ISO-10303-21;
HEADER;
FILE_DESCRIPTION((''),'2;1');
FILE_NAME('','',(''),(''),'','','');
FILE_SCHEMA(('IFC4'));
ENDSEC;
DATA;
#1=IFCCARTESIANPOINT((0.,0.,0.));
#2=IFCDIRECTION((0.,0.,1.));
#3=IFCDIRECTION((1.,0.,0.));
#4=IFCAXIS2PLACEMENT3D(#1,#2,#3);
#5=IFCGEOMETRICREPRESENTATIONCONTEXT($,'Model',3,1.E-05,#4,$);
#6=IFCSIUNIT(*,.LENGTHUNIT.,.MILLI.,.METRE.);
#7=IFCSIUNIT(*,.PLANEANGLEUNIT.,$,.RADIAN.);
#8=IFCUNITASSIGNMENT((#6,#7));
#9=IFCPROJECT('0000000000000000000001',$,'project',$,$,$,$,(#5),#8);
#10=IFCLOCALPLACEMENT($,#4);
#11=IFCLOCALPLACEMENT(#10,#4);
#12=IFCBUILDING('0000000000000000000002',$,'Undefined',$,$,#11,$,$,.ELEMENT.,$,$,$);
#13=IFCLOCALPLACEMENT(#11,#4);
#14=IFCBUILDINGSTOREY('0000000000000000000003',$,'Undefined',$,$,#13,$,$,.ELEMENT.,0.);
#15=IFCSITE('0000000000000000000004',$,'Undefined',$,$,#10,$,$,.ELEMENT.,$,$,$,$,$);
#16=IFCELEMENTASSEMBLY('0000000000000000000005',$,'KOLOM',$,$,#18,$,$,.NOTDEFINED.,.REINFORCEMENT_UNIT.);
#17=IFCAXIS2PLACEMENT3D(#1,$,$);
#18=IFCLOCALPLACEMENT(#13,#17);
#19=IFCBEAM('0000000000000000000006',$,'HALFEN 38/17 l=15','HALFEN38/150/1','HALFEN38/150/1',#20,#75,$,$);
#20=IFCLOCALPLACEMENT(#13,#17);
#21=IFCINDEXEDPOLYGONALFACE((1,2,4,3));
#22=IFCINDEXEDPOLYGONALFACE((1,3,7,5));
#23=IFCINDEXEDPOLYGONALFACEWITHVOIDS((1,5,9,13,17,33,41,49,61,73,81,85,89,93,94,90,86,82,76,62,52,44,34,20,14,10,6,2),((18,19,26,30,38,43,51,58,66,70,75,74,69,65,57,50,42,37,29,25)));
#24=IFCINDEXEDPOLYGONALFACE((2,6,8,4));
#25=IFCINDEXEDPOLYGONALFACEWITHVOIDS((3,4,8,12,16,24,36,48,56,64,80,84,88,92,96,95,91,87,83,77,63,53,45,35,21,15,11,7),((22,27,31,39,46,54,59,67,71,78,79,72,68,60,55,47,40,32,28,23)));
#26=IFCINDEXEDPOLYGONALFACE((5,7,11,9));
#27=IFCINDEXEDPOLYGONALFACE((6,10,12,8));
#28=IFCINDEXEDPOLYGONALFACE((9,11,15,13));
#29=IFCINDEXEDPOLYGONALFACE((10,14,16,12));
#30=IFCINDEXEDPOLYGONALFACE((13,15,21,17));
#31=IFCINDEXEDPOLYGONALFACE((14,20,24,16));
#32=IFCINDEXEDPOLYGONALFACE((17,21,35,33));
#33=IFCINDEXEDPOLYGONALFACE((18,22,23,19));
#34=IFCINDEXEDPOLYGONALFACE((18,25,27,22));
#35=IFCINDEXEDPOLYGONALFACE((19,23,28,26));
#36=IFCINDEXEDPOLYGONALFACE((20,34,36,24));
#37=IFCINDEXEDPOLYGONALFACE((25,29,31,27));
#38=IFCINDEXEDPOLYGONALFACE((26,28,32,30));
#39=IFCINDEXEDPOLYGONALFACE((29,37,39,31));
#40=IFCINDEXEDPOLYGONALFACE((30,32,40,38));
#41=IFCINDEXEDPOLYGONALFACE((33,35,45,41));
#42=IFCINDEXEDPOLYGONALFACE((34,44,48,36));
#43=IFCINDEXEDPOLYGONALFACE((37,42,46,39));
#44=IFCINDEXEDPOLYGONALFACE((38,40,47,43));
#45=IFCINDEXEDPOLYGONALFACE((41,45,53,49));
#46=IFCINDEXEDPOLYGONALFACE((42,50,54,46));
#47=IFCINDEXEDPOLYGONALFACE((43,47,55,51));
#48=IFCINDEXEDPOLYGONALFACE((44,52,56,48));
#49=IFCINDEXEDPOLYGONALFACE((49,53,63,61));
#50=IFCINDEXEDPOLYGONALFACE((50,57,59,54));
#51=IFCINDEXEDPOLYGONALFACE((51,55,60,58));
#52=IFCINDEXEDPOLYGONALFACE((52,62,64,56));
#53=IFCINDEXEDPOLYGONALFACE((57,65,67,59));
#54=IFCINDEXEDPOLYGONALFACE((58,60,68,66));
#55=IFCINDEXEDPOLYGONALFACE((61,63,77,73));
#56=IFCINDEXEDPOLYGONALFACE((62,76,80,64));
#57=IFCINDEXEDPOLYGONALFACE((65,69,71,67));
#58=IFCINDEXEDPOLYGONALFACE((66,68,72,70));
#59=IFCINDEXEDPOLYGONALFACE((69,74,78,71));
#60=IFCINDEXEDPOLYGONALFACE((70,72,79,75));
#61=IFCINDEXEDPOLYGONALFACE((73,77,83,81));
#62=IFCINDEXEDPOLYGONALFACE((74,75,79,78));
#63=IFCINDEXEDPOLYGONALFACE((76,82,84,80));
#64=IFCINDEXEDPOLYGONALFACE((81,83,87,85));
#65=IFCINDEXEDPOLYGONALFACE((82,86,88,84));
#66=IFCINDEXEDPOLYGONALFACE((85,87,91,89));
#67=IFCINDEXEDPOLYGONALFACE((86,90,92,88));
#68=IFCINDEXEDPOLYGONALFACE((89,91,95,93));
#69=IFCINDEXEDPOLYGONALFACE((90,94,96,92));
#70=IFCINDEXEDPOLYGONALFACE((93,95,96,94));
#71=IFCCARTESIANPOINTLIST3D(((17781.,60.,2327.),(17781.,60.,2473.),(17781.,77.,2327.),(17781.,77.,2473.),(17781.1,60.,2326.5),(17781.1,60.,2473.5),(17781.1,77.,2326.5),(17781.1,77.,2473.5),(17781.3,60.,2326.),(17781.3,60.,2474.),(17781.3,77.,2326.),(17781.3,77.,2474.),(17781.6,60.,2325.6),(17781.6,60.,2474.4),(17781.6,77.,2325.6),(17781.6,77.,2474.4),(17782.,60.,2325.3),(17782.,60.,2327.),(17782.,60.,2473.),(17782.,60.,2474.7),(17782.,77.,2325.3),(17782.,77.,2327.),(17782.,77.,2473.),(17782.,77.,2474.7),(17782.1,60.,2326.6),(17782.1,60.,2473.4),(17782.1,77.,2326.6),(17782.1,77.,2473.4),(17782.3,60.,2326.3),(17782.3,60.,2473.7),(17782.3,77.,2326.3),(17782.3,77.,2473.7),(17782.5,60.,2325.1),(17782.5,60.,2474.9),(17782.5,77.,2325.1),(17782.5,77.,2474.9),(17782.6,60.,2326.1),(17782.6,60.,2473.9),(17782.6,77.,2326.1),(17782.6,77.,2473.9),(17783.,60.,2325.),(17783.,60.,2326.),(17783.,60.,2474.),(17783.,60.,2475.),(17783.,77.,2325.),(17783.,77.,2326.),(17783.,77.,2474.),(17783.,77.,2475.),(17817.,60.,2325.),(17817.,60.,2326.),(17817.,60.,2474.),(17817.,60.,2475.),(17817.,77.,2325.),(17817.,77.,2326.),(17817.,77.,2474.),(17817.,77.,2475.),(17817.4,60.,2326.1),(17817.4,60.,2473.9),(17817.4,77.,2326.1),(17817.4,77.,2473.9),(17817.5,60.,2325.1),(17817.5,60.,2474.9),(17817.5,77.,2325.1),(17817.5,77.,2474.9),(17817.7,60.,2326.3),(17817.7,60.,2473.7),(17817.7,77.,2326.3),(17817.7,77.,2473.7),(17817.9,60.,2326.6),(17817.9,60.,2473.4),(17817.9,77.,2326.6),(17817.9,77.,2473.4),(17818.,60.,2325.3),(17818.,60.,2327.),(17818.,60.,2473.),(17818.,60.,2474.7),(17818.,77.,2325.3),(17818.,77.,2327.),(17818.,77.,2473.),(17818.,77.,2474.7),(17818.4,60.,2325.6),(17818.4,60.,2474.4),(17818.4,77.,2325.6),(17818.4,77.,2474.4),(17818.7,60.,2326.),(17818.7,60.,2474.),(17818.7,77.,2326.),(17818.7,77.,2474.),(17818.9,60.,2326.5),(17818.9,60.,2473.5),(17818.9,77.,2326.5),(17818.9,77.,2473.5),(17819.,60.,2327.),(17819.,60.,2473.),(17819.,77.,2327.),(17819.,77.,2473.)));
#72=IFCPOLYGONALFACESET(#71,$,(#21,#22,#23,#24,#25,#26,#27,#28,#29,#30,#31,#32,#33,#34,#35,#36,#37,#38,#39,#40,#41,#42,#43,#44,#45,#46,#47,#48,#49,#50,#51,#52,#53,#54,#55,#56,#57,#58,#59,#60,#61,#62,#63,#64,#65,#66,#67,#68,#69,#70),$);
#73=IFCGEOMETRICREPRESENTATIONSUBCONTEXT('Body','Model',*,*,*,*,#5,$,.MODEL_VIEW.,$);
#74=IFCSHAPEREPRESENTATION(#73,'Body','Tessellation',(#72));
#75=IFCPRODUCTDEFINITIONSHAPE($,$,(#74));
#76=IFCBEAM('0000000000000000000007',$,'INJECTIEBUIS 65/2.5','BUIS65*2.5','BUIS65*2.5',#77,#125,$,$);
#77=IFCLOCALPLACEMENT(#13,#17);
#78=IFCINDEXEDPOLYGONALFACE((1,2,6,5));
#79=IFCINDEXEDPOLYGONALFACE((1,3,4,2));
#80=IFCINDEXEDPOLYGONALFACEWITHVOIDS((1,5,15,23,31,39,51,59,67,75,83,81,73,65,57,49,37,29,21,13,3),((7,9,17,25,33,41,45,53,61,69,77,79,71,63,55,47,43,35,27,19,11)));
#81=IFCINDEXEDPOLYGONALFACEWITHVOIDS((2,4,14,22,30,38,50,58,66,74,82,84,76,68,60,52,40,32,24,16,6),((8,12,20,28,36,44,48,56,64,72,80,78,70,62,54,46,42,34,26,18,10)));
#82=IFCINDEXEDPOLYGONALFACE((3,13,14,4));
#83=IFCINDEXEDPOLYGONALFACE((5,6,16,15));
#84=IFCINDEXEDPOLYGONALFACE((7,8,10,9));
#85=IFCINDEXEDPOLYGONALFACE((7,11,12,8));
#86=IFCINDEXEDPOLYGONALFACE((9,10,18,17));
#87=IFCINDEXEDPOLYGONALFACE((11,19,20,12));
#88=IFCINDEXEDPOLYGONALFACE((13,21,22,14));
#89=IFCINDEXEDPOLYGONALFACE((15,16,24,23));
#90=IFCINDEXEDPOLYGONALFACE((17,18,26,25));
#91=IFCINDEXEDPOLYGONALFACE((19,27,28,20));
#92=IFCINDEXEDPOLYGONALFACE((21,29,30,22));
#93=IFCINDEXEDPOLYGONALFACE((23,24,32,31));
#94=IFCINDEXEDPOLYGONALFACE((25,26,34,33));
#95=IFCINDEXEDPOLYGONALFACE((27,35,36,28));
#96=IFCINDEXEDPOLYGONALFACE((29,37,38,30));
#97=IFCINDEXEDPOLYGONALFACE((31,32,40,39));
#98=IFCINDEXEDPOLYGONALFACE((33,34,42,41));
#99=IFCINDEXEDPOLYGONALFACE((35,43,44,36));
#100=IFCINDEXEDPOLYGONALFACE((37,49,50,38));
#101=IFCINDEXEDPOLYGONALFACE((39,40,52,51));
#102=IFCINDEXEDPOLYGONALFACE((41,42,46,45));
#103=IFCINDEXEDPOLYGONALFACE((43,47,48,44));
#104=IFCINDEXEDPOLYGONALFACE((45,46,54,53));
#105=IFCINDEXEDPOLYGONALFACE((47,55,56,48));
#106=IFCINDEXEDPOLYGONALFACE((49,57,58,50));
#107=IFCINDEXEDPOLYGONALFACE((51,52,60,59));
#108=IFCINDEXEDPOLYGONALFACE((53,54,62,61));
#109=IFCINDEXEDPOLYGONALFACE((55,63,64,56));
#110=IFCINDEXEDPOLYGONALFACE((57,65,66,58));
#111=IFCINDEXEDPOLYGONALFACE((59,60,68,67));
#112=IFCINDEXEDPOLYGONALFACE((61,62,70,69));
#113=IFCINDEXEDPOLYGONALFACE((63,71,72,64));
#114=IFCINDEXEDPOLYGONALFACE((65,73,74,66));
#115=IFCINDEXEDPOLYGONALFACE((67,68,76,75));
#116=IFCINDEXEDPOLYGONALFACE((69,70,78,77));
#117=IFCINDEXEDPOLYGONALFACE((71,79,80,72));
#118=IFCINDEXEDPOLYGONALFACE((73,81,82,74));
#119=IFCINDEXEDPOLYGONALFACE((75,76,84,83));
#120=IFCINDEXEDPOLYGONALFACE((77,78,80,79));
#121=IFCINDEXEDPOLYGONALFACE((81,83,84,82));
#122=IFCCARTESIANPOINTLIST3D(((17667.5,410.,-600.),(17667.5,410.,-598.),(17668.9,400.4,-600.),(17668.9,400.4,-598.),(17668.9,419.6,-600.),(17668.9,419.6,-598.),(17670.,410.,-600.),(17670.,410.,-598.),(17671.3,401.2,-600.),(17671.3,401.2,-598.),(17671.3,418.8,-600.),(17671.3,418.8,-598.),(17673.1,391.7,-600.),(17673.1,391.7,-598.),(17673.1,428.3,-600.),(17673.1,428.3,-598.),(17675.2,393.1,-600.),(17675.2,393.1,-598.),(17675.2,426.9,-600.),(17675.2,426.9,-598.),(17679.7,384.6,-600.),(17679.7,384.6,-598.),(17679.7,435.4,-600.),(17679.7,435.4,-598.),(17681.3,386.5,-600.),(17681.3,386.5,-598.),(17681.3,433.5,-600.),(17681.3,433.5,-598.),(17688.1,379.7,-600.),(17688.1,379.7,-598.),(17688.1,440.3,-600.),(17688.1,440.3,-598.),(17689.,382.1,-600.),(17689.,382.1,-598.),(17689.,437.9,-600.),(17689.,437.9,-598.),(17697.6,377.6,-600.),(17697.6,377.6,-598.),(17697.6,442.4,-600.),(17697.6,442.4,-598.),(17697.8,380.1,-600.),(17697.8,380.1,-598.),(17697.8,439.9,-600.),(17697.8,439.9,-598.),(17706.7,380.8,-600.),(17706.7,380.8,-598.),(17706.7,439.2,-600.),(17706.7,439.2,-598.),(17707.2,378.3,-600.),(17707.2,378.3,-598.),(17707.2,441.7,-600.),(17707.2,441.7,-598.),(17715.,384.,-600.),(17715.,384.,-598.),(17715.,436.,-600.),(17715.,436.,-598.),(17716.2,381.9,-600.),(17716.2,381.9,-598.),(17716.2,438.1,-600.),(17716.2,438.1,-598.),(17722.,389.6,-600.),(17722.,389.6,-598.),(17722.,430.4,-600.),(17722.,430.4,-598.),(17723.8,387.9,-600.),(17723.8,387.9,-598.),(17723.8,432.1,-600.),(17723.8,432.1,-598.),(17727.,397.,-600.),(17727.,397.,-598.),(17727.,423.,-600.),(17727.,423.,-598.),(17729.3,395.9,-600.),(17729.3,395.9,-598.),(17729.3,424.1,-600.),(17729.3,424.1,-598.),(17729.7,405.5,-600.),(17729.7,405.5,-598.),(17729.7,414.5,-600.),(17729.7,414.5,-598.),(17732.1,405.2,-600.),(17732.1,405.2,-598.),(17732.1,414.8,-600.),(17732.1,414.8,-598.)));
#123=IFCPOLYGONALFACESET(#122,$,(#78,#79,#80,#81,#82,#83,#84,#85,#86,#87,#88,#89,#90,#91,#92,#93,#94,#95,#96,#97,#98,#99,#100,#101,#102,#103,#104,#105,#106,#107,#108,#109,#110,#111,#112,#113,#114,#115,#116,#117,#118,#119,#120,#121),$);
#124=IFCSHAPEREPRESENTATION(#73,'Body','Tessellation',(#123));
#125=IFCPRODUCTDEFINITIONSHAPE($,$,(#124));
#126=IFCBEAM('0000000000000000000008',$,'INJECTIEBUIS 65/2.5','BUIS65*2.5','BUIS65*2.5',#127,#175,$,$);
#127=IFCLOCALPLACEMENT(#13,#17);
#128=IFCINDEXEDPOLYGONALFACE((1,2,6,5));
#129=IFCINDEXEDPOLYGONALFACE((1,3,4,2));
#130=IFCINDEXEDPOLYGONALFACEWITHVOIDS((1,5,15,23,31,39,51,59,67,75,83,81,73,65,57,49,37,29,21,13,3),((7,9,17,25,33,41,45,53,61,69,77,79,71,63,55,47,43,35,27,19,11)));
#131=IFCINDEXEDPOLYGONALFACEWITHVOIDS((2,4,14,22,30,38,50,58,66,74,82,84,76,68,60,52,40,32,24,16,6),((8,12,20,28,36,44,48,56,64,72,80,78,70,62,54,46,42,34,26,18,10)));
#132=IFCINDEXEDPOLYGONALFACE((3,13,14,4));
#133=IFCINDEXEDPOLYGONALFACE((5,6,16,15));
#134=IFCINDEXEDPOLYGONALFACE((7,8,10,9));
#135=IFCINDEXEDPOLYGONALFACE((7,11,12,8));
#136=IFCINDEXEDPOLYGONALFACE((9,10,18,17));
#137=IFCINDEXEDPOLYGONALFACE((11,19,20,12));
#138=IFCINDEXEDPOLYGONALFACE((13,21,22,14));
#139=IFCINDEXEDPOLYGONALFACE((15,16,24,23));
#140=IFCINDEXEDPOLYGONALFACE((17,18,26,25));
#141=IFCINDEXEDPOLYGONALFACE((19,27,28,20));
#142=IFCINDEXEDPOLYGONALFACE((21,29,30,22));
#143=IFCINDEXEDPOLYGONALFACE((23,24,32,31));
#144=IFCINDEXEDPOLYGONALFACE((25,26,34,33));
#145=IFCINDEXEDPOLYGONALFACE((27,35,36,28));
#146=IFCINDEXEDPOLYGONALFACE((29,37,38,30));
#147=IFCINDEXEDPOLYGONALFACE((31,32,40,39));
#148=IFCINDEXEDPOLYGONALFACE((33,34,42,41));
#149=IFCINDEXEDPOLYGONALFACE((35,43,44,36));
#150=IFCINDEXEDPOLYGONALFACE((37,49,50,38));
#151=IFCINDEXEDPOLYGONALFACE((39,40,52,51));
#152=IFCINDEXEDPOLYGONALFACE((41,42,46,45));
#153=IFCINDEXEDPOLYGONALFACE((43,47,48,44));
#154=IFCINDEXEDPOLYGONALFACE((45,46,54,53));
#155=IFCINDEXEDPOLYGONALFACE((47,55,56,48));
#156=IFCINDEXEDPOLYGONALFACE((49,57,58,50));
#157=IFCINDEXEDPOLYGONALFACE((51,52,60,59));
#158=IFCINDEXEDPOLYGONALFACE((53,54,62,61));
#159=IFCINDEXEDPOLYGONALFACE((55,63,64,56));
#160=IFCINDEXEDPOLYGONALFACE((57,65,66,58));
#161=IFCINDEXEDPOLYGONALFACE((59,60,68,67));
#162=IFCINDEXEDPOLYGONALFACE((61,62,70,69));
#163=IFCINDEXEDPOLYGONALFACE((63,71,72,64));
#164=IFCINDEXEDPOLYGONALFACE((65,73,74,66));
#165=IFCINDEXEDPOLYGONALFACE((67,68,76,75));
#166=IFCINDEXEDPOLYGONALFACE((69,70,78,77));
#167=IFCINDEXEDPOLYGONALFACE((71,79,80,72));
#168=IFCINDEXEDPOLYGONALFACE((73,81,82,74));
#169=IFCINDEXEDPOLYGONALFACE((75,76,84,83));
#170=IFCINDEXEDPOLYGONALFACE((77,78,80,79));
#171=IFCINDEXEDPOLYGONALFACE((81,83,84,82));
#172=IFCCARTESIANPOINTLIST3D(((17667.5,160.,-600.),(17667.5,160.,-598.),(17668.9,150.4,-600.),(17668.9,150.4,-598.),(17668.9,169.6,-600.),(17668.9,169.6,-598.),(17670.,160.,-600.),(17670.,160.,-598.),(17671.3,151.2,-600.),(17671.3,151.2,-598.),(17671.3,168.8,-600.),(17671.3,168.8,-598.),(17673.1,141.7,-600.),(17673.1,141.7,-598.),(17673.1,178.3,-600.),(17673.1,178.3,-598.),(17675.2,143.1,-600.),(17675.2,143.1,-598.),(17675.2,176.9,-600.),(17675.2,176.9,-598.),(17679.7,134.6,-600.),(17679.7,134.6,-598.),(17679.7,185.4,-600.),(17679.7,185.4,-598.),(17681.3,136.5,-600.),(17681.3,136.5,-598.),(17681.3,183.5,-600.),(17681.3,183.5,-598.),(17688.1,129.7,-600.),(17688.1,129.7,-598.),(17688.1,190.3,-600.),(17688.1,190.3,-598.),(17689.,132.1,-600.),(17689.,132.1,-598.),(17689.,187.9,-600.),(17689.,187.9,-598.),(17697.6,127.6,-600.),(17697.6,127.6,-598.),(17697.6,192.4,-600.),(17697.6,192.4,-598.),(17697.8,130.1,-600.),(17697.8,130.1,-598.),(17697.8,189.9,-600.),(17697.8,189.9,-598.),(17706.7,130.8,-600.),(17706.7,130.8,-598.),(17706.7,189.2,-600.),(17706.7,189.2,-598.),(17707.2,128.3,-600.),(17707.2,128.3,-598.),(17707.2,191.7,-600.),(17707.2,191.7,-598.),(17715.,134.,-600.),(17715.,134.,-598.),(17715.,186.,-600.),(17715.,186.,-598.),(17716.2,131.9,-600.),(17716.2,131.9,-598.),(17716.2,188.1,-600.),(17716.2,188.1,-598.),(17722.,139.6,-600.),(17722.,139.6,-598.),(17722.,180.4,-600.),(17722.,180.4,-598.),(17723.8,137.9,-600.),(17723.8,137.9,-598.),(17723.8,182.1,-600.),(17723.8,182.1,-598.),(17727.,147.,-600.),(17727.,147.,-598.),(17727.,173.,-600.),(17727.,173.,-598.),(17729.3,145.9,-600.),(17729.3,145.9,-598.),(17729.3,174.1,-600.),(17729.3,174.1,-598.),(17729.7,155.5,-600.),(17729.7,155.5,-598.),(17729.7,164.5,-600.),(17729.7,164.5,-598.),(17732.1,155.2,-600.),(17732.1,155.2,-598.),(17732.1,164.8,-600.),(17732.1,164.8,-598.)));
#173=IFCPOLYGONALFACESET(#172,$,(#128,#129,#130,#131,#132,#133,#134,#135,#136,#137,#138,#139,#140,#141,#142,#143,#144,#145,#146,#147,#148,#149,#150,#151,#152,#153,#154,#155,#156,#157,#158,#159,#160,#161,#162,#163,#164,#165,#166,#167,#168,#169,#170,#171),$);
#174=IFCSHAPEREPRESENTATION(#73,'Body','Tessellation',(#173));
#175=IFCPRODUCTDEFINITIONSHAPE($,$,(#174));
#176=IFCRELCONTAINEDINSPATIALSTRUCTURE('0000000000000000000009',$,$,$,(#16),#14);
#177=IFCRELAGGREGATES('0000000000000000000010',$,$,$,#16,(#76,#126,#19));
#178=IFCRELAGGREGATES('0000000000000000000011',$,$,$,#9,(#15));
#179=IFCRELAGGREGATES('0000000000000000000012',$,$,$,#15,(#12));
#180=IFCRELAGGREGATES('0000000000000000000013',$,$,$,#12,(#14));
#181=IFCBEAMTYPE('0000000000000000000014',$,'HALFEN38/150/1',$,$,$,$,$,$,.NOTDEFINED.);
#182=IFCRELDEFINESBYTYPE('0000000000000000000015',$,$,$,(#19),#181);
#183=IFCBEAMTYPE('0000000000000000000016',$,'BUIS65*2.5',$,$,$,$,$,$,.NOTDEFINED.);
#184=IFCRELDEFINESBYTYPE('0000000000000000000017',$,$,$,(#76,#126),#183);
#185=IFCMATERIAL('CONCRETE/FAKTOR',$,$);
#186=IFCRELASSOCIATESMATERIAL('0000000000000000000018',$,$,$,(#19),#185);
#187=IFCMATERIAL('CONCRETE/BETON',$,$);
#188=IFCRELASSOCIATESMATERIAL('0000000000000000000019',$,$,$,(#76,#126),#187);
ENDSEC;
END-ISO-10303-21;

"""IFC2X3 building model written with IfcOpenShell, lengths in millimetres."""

from ifc_helpers import new_model, si_unit, frame, frame_2d, origin_with_axes, place, context, subcontext, project, spatial, hollow_rectangle, hollow_circle, extrude, material, type_object, element, aggregate, save


model = new_model("IFC2X3")

# Units and contexts
model_context = context("Model", 3, precision=1e-05, world=origin_with_axes())
body_context = subcontext(model_context, "Body", "Model", "MODEL_VIEW")
ifc_project = project(units=[si_unit("LENGTHUNIT", "METRE", prefix="MILLI"), si_unit("PLANEANGLEUNIT", "RADIAN")], contexts=[model_context])

# Site, building, storey
site_placement = place(None, origin_with_axes())
site = spatial("IfcSite", under=ifc_project, at=site_placement, Name="Undefined", CompositionType="ELEMENT")
building_placement = place(site_placement, origin_with_axes())
building = spatial("IfcBuilding", under=site, at=building_placement, Name="Undefined", CompositionType="ELEMENT")
storey_placement = place(building_placement, origin_with_axes())
storey = spatial("IfcBuildingStorey", under=building, at=storey_placement, Name="Undefined", CompositionType="ELEMENT", Elevation=0.0)

# Shared definitions
ifc_material_1 = material(Name="CONCRETE/FAKTOR")
ifc_material_2 = material(Name="CONCRETE/BETON")
beam_type_1 = type_object("IfcBeamType", Name="HALFEN38/150/1", PredefinedType="NOTDEFINED")

# Element assembly, beams
assembly_1_placement = place(storey_placement, origin_with_axes())
assembly_1 = element("IfcElementAssembly", 1, at=assembly_1_placement, inside=storey, Name="KOLOM", AssemblyPlace="NOTDEFINED", PredefinedType="REINFORCEMENT_UNIT")
beam_1_placement = place(assembly_1_placement, frame((17800.0, 60.0, 2400.0), z_axis=(1.0, 0.0, 0.0), x_axis=(0.0, 1.0, 0.0)))
beam_1 = element("IfcBeam", 2, at=beam_1_placement, type_object=beam_type_1, material=ifc_material_1, Name="HALFEN 38/17 l=15", Description="HALFEN38/150/1", ObjectType="HALFEN38/150/1", context=body_context, shape_type="SweptSolid", body=[
    extrude(hollow_rectangle(XDim=150.0, YDim=38.0, WallThickness=1.0, InnerFilletRadius=1.0, OuterFilletRadius=2.0, at=frame_2d((0.0, 0.0), x_axis=(1.0, 0.0))), frame((17.0, 0.0, 0.0), z_axis=(-1.0, 0.0, 0.0), x_axis=(0.0, -1.0, 0.0)), (0.0, 0.0, 1.0), 17.0),
])
beam_type_2 = type_object("IfcBeamType", Name="BUIS65*2.5", PredefinedType="NOTDEFINED")
beam_2_placement = place(assembly_1_placement, frame((17700.0, 410.0, -600.0), z_axis=(0.0, 1.0, 0.0), x_axis=(0.0, 0.0, 1.0)))
beam_2 = element("IfcBeam", 3, at=beam_2_placement, type_object=beam_type_2, material=ifc_material_2, Name="INJECTIEBUIS 65/2.5", Description="BUIS65*2.5", ObjectType="BUIS65*2.5", context=body_context, shape_type="SweptSolid", body=[
    extrude(hollow_circle(Radius=32.5, WallThickness=2.5, at=frame_2d((0.0, 0.0), x_axis=(1.0, 0.0))), frame((2.0, 0.0, 0.0), z_axis=(-1.0, 0.0, 0.0), x_axis=(0.0, -1.0, 0.0)), (0.0, 0.0, 1.0), 2.0),
])
beam_3_placement = place(assembly_1_placement, frame((17700.0, 160.0, -600.0), z_axis=(0.0, 1.0, 0.0), x_axis=(0.0, 0.0, 1.0)))
beam_3 = element("IfcBeam", 4, at=beam_3_placement, type_object=beam_type_2, material=ifc_material_2, Name="INJECTIEBUIS 65/2.5", Description="BUIS65*2.5", ObjectType="BUIS65*2.5", context=body_context, shape_type="SweptSolid", body=[
    extrude(hollow_circle(Radius=32.5, WallThickness=2.5, at=frame_2d((0.0, 0.0), x_axis=(1.0, 0.0))), frame((2.0, 0.0, 0.0), z_axis=(-1.0, 0.0, 0.0), x_axis=(0.0, -1.0, 0.0)), (0.0, 0.0, 1.0), 2.0),
])
aggregate(assembly_1, [beam_2, beam_3, beam_1])

save(model, "model.ifc")
